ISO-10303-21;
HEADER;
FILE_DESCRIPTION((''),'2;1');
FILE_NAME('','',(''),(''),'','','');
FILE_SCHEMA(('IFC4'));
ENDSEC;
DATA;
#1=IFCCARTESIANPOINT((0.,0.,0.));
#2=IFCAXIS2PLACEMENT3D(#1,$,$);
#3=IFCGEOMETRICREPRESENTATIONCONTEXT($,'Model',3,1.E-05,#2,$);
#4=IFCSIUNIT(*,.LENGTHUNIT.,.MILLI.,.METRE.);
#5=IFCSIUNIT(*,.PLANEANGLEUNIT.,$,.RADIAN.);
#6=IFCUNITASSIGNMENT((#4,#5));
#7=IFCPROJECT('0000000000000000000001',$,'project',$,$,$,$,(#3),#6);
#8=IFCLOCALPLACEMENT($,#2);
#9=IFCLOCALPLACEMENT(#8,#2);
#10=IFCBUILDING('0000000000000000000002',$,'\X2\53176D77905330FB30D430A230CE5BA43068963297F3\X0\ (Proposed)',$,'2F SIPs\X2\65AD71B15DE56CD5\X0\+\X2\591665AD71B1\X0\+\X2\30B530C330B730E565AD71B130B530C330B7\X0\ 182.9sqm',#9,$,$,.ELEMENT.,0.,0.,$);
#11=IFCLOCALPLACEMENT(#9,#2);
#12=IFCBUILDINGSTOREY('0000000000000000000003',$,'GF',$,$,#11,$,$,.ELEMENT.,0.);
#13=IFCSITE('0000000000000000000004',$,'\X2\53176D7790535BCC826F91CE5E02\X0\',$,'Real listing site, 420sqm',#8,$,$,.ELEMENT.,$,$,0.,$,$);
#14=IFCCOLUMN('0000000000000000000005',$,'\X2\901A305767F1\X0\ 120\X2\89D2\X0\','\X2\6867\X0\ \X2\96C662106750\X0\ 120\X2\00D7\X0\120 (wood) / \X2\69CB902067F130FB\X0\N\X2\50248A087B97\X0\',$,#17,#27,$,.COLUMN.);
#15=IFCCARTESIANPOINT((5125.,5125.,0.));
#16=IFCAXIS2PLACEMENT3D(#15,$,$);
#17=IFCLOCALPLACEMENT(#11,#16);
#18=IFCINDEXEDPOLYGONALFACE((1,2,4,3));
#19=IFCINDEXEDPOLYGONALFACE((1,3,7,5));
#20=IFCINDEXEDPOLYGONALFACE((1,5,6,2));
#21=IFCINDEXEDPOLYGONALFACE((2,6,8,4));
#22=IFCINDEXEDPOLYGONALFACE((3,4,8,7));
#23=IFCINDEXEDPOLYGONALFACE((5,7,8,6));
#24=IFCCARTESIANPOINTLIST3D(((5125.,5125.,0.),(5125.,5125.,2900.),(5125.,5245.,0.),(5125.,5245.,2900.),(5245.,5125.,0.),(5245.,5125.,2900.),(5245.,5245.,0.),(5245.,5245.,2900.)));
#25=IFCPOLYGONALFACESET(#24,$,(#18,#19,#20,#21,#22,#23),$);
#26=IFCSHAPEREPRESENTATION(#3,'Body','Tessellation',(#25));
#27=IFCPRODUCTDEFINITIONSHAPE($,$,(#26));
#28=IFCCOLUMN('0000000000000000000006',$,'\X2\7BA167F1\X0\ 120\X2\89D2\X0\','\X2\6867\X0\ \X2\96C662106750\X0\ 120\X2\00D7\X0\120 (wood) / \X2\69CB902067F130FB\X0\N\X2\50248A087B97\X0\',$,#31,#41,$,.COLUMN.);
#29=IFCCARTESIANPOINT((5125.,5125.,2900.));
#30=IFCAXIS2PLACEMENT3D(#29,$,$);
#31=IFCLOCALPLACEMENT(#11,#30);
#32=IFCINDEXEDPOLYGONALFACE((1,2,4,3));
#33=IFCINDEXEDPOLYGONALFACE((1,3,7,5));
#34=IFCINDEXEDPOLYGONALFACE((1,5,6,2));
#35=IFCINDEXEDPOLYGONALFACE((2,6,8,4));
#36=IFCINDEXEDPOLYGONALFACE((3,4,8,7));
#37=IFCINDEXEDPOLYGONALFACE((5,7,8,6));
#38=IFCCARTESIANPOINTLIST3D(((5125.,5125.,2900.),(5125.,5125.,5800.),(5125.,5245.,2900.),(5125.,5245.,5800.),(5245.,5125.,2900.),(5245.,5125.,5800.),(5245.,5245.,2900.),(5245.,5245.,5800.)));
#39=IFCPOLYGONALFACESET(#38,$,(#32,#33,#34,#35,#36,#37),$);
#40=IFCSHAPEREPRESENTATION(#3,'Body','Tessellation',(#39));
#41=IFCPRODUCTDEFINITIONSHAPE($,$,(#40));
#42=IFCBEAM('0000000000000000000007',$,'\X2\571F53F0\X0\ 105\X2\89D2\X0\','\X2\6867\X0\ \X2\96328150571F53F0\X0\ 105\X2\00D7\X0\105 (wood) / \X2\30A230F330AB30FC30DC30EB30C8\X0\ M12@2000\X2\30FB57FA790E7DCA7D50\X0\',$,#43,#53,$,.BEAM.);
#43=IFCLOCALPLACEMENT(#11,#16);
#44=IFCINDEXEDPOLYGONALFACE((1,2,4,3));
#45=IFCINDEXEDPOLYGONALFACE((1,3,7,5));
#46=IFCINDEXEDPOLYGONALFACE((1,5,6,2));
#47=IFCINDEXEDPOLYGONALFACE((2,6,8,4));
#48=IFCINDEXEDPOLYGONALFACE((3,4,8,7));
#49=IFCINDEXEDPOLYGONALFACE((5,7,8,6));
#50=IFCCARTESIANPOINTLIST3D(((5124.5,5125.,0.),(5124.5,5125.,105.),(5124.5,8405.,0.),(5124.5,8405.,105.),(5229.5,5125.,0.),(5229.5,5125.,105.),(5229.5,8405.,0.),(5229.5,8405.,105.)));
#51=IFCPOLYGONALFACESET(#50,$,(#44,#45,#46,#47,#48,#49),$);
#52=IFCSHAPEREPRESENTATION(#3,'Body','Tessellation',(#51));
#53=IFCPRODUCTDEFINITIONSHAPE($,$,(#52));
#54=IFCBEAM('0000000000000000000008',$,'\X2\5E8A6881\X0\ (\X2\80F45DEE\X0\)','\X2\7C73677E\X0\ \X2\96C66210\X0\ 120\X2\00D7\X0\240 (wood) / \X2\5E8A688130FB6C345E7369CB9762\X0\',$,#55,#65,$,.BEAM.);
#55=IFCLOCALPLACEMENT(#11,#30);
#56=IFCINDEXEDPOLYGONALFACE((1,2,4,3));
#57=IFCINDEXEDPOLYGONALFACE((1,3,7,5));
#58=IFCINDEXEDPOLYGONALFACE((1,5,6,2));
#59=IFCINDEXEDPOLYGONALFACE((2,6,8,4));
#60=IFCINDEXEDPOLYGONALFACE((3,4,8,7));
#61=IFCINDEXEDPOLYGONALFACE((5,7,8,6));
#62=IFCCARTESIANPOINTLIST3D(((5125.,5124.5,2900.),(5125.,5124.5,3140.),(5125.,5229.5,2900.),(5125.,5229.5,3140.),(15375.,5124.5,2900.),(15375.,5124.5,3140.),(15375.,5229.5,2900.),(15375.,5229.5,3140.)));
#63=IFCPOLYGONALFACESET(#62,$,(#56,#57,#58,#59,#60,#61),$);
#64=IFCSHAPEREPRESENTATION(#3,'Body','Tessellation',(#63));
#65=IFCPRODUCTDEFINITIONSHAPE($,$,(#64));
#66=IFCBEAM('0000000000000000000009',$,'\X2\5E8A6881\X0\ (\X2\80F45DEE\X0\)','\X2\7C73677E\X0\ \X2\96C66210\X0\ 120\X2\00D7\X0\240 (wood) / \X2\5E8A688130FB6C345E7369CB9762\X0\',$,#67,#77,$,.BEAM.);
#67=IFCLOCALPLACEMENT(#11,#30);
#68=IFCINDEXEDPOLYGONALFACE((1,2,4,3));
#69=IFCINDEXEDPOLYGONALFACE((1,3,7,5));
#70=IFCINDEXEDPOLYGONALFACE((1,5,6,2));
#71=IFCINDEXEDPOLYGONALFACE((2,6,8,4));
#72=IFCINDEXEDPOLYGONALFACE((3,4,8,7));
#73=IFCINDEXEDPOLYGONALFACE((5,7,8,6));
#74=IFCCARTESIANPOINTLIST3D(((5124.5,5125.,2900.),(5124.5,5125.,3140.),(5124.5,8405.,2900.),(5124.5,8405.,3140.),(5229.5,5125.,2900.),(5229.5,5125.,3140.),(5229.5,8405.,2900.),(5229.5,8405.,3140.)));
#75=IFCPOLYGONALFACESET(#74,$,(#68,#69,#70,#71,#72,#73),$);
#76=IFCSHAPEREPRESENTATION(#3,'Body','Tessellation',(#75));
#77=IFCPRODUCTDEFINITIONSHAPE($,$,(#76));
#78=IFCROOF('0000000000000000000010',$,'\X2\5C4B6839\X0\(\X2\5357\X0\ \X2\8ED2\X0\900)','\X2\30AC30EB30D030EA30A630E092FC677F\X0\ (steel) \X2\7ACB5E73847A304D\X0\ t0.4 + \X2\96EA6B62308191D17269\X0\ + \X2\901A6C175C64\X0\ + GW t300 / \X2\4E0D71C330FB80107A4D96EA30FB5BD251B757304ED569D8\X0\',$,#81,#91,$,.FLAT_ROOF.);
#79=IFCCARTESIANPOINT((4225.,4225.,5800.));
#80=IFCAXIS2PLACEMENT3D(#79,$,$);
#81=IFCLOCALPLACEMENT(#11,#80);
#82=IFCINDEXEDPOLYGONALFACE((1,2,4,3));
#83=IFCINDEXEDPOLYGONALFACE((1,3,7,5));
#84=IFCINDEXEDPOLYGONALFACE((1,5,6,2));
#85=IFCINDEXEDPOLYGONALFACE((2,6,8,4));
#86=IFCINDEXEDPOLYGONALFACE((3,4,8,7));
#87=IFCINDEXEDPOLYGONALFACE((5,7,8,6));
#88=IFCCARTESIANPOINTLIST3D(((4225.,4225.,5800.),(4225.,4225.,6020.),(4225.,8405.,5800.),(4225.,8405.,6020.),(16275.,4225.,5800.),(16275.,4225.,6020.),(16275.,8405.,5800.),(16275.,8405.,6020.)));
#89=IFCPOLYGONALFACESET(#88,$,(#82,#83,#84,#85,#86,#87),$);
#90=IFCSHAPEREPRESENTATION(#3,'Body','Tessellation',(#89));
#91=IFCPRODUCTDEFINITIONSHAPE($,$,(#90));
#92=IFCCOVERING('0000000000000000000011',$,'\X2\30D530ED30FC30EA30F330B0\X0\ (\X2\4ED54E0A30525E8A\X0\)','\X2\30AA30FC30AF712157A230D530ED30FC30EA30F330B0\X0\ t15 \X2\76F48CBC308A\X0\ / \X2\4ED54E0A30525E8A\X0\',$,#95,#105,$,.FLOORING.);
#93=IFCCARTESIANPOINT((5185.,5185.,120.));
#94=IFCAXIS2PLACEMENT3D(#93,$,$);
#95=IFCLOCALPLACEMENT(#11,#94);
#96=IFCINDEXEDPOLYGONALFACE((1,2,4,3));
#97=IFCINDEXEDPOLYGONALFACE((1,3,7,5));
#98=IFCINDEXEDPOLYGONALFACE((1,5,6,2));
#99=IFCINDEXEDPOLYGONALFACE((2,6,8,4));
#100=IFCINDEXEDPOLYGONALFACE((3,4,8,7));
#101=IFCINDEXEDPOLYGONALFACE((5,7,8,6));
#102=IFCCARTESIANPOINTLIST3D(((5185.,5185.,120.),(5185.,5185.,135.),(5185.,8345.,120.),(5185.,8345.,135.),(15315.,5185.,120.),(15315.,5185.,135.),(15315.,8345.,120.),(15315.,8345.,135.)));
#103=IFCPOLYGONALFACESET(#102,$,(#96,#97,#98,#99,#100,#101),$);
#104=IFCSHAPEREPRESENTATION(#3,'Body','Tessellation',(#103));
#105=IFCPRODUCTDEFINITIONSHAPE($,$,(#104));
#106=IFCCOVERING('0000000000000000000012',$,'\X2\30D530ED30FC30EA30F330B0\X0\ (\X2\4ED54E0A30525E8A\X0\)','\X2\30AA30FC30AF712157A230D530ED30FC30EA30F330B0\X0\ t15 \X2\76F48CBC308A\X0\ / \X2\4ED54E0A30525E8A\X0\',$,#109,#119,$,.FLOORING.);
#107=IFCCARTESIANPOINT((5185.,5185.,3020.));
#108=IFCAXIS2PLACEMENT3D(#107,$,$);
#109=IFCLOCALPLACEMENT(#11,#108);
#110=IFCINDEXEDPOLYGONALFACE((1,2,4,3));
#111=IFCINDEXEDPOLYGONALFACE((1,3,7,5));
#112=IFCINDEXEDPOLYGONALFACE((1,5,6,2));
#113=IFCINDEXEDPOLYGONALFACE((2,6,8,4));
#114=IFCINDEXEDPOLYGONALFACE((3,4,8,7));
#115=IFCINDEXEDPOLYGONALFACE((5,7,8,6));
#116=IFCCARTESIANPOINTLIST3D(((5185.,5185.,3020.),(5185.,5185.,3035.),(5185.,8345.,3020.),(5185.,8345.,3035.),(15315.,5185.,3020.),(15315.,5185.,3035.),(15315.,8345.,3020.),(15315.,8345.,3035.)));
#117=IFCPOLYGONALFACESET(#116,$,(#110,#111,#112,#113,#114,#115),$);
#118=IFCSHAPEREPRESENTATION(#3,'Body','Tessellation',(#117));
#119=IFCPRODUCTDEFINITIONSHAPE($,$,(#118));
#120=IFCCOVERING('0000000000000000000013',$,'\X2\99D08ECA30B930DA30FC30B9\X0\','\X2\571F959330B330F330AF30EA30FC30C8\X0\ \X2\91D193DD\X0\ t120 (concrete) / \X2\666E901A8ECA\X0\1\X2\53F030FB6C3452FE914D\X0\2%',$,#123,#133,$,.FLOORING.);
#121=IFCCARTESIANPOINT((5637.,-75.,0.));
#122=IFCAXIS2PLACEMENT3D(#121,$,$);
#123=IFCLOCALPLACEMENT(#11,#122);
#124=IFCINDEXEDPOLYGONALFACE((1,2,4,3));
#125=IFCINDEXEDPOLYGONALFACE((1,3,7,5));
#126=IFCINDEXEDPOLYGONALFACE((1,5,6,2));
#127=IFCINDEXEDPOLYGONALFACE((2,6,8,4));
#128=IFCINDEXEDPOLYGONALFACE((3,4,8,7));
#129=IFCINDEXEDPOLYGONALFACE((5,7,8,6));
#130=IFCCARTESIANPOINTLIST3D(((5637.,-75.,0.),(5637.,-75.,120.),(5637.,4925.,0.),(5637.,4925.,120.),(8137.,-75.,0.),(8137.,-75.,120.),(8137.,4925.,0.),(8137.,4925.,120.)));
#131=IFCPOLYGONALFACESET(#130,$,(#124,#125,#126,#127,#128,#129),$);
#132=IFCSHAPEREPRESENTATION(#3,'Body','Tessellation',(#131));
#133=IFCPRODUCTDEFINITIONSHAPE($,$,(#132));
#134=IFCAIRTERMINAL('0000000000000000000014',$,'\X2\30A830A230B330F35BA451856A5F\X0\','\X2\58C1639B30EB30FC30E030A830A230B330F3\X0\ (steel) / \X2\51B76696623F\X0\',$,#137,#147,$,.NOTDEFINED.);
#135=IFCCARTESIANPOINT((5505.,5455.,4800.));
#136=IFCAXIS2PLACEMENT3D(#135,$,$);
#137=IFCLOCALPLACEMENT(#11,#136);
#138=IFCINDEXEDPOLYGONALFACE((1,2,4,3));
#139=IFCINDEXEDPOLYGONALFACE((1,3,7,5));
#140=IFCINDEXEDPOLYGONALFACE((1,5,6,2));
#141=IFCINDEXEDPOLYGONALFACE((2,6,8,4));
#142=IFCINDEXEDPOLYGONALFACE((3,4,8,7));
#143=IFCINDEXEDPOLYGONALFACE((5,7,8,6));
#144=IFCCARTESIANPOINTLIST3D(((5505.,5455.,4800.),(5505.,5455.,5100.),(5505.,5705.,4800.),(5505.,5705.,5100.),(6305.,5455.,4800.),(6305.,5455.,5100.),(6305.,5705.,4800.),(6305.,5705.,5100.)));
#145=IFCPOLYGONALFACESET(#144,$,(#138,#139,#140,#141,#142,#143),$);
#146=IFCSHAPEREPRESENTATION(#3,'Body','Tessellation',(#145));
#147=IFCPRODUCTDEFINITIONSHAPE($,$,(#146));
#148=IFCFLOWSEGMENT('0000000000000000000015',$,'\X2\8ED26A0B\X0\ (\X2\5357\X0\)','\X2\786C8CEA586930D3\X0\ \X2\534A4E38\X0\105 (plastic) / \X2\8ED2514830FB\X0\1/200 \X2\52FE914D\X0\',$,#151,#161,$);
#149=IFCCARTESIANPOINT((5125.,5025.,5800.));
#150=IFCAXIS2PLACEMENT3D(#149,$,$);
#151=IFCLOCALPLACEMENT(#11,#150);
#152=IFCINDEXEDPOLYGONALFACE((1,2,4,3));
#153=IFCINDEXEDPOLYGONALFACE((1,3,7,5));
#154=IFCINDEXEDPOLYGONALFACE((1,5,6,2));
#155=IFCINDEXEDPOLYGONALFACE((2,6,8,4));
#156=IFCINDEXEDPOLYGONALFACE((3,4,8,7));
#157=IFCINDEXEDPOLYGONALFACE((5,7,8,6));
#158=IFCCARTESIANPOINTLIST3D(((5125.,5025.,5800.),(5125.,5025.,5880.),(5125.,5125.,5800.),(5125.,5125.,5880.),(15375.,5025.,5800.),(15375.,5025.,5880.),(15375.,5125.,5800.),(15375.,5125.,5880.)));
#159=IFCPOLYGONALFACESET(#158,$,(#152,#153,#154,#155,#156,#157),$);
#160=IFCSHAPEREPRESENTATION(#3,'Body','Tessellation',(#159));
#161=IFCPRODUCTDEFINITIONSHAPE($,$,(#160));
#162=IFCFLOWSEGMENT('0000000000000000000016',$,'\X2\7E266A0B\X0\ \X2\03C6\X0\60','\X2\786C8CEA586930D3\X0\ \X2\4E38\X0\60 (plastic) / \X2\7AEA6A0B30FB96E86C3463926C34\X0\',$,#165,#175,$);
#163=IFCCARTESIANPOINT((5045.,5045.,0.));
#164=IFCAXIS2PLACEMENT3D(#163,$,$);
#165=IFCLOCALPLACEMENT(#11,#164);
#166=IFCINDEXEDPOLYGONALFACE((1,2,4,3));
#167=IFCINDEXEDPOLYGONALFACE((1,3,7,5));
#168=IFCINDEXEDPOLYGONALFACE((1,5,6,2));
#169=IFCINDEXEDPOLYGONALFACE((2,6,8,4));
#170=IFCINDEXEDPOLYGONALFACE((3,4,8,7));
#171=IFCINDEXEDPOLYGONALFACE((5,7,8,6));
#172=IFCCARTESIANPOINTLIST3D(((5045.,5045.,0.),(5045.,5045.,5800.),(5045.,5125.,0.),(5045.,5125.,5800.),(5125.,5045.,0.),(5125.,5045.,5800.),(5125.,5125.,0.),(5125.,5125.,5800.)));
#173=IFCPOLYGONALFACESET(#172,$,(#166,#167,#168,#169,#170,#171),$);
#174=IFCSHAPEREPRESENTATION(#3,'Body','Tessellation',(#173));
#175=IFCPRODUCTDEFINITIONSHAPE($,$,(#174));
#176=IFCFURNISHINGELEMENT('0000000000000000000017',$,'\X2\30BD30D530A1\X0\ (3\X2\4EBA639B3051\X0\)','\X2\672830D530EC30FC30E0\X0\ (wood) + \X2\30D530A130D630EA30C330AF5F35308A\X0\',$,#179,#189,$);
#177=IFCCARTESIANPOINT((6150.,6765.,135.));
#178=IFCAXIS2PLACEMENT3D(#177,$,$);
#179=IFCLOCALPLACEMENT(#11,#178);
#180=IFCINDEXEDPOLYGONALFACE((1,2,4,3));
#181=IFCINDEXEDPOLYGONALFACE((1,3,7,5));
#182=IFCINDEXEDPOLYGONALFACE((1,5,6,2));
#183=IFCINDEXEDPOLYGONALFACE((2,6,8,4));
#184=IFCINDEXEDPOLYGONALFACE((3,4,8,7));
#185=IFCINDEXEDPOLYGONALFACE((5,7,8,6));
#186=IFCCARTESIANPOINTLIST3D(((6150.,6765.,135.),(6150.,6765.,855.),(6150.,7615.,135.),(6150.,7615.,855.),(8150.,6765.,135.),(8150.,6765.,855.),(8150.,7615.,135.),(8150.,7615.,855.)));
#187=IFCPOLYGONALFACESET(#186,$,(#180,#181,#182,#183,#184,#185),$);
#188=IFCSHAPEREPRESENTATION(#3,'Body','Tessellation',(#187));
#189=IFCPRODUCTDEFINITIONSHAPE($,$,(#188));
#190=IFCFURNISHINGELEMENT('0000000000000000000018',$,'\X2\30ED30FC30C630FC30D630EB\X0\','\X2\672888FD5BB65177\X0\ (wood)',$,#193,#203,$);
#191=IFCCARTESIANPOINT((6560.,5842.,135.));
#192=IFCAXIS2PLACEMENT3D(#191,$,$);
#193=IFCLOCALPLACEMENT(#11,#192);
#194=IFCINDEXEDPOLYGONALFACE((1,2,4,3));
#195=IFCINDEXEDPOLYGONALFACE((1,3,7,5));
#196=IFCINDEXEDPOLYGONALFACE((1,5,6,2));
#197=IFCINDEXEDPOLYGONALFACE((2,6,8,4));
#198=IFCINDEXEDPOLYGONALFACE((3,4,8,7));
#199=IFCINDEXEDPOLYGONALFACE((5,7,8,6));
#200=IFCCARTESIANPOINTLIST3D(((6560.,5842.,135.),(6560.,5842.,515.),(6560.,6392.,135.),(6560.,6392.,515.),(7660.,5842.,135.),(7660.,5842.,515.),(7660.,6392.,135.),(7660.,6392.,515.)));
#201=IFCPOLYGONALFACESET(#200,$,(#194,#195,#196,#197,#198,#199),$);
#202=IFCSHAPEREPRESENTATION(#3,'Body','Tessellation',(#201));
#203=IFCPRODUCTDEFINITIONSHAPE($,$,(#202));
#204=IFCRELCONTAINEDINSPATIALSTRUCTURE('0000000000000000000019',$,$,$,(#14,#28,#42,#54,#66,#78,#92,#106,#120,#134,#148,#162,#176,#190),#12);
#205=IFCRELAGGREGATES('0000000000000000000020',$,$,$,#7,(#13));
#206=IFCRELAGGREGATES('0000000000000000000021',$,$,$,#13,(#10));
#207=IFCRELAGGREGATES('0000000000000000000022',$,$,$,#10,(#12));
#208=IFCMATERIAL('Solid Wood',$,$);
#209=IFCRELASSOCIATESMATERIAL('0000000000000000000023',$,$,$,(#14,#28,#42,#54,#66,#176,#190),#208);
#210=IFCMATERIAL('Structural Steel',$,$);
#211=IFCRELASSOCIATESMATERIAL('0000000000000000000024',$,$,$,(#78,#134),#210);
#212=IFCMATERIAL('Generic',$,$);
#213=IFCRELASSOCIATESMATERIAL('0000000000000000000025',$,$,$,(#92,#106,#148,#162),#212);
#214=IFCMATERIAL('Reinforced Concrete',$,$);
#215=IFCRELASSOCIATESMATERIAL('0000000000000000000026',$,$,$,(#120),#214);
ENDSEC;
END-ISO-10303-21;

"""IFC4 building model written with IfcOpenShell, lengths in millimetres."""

from ifc_helpers import new_model, si_unit, frame, frame_2d, origin, place, context, project, spatial, rectangle, extrude, material, element, save


model = new_model("IFC4")

# Units and contexts
model_context = context("Model", 3, precision=1e-05, world=origin())
ifc_project = project(units=[si_unit("LENGTHUNIT", "METRE", prefix="MILLI"), si_unit("PLANEANGLEUNIT", "RADIAN")], contexts=[model_context])

# Site, building, storey
site_placement = place(None, origin())
site = spatial("IfcSite", under=ifc_project, at=site_placement, Name="北海道富良野市", ObjectType="Real listing site, 420sqm", CompositionType="ELEMENT", RefElevation=0.0)
building_placement = place(site_placement, origin())
building = spatial("IfcBuilding", under=site, at=building_placement, Name="北海道・ピアノ室と防音 (Proposed)", ObjectType="2F SIPs断熱工法+外断熱+サッシュ断熱サッシ 182.9sqm", CompositionType="ELEMENT", ElevationOfRefHeight=0.0, ElevationOfTerrain=0.0)
storey_placement = place(building_placement, origin())
storey = spatial("IfcBuildingStorey", under=building, at=storey_placement, Name="GF", CompositionType="ELEMENT", Elevation=0.0)

# Columns
ifc_material_1 = material(Name="Solid Wood")
column_1_placement = place(storey_placement, frame((5125.0, 5125.0, 0.0)))
element("IfcColumn", 1, at=column_1_placement, inside=storey, material=ifc_material_1, Name="通し柱 120角", Description="桧 集成材 120×120 (wood) / 構造柱・N値計算", PredefinedType="COLUMN", context=model_context, shape_type="SweptSolid", body=[
    extrude(rectangle(XDim=120.0, YDim=120.0, at=frame_2d((60.0, 60.0))), frame((5125.0, 5125.0, 0.0)), (0.0, 0.0, 1.0), 2900.0),
])
column_2_placement = place(storey_placement, frame((5125.0, 5125.0, 2900.0)))
element("IfcColumn", 2, at=column_2_placement, inside=storey, material=ifc_material_1, Name="管柱 120角", Description="桧 集成材 120×120 (wood) / 構造柱・N値計算", PredefinedType="COLUMN", context=model_context, shape_type="SweptSolid", body=[
    extrude(rectangle(XDim=120.0, YDim=120.0, at=frame_2d((60.0, 60.0))), frame((5125.0, 5125.0, 2900.0)), (0.0, 0.0, 1.0), 2900.0),
])

# Beams
beam_1_placement = place(storey_placement, frame((5125.0, 5125.0, 0.0)))
element("IfcBeam", 3, at=beam_1_placement, inside=storey, material=ifc_material_1, Name="土台 105角", Description="桧 防腐土台 105×105 (wood) / アンカーボルト M12@2000・基礎緊結", PredefinedType="BEAM", context=model_context, shape_type="SweptSolid", body=[
    extrude(rectangle(XDim=105.0, YDim=3280.0, at=frame_2d((52.0, 1640.0))), frame((5125.0, 5125.0, 0.0)), (0.0, 0.0, 1.0), 105.0),
])
beam_2_placement = place(storey_placement, frame((5125.0, 5125.0, 2900.0)))
element("IfcBeam", 4, at=beam_2_placement, inside=storey, material=ifc_material_1, Name="床梁 (胴差)", Description="米松 集成 120×240 (wood) / 床梁・水平構面", PredefinedType="BEAM", context=model_context, shape_type="SweptSolid", body=[
    extrude(rectangle(XDim=10250.0, YDim=105.0, at=frame_2d((5125.0, 52.0))), frame((5125.0, 5125.0, 2900.0)), (0.0, 0.0, 1.0), 240.0),
])
beam_3_placement = place(storey_placement, frame((5125.0, 5125.0, 2900.0)))
element("IfcBeam", 5, at=beam_3_placement, inside=storey, material=ifc_material_1, Name="床梁 (胴差)", Description="米松 集成 120×240 (wood) / 床梁・水平構面", PredefinedType="BEAM", context=model_context, shape_type="SweptSolid", body=[
    extrude(rectangle(XDim=105.0, YDim=3280.0, at=frame_2d((52.0, 1640.0))), frame((5125.0, 5125.0, 2900.0)), (0.0, 0.0, 1.0), 240.0),
])

# Shared definitions
ifc_material_2 = material(Name="Reinforced Concrete")

# Roof
ifc_material_3 = material(Name="Structural Steel")
for number, where, name in (
    (6, (4225.0, 4225.0, 5800.0), "屋根(南 軒900)"),
):
    element("IfcRoof", number, at=place(storey_placement, frame(where)), inside=storey, material=ifc_material_3, Name=name, Description="ガルバリウム鋼板 (steel) 立平葺き t0.4 + 雪止め金物 + 通気層 + GW t300 / 不燃・耐積雪・寒冷地仕様", PredefinedType="FLAT_ROOF", context=model_context, shape_type="SweptSolid", body=[
        extrude(rectangle(XDim=12050.0, YDim=4180.0, at=frame_2d((6025.0, 2090.0))), frame((4225.0, 4225.0, 5800.0)), (0.0, 0.0, 1.0), 220.0),
    ])

# Coverings
ifc_material_4 = material(Name="Generic")
covering_1_placement = place(storey_placement, frame((5185.0, 5185.0, 120.0)))
element("IfcCovering", 7, at=covering_1_placement, inside=storey, material=ifc_material_4, Name="フローリング (仕上げ床)", Description="オーク無垢フローリング t15 直貼り / 仕上げ床", PredefinedType="FLOORING", context=model_context, shape_type="SweptSolid", body=[
    extrude(rectangle(XDim=10130.0, YDim=3160.0, at=frame_2d((5065.0, 1580.0))), frame((5185.0, 5185.0, 120.0)), (0.0, 0.0, 1.0), 15.0),
])
covering_2_placement = place(storey_placement, frame((5185.0, 5185.0, 3020.0)))
element("IfcCovering", 8, at=covering_2_placement, inside=storey, material=ifc_material_4, Name="フローリング (仕上げ床)", Description="オーク無垢フローリング t15 直貼り / 仕上げ床", PredefinedType="FLOORING", context=model_context, shape_type="SweptSolid", body=[
    extrude(rectangle(XDim=10130.0, YDim=3160.0, at=frame_2d((5065.0, 1580.0))), frame((5185.0, 5185.0, 3020.0)), (0.0, 0.0, 1.0), 15.0),
])
covering_3_placement = place(storey_placement, frame((5637.0, -75.0, 0.0)))
element("IfcCovering", 9, at=covering_3_placement, inside=storey, material=ifc_material_2, Name="駐車スペース", Description="土間コンクリート 金鏝 t120 (concrete) / 普通車1台・水勾配2%", PredefinedType="FLOORING", context=model_context, shape_type="SweptSolid", body=[
    extrude(rectangle(XDim=2500.0, YDim=5000.0, at=frame_2d((1250.0, 2500.0))), frame((5637.0, -75.0, 0.0)), (0.0, 0.0, 1.0), 120.0),
])

# Air terminal
air_terminal_placement = place(storey_placement, frame((5505.0, 5455.0, 4800.0)))
element("IfcAirTerminal", 10, at=air_terminal_placement, inside=storey, material=ifc_material_3, Name="エアコン室内機", Description="壁掛ルームエアコン (steel) / 冷暖房", PredefinedType="NOTDEFINED", context=model_context, shape_type="SweptSolid", body=[
    extrude(rectangle(XDim=800.0, YDim=250.0, at=frame_2d((400.0, 125.0))), frame((5505.0, 5455.0, 4800.0)), (0.0, 0.0, 1.0), 300.0),
])

# Flow segments
flow_segment_1_placement = place(storey_placement, frame((5125.0, 5025.0, 5800.0)))
element("IfcFlowSegment", 11, at=flow_segment_1_placement, inside=storey, material=ifc_material_4, Name="軒樋 (南)", Description="硬質塩ビ 半丸105 (plastic) / 軒先・1/200 勾配", context=model_context, shape_type="SweptSolid", body=[
    extrude(rectangle(XDim=10250.0, YDim=100.0, at=frame_2d((5125.0, 50.0))), frame((5125.0, 5025.0, 5800.0)), (0.0, 0.0, 1.0), 80.0),
])
flow_segment_2_placement = place(storey_placement, frame((5045.0, 5045.0, 0.0)))
element("IfcFlowSegment", 12, at=flow_segment_2_placement, inside=storey, material=ifc_material_4, Name="縦樋 φ60", Description="硬質塩ビ 丸60 (plastic) / 竪樋・雨水排水", context=model_context, shape_type="SweptSolid", body=[
    extrude(rectangle(XDim=80.0, YDim=80.0, at=frame_2d((40.0, 40.0))), frame((5045.0, 5045.0, 0.0)), (0.0, 0.0, 1.0), 5800.0),
])

# Furnishing elements
furnishing_1_placement = place(storey_placement, frame((6150.0, 6765.0, 135.0)))
element("IfcFurnishingElement", 13, at=furnishing_1_placement, inside=storey, material=ifc_material_1, Name="ソファ (3人掛け)", Description="木フレーム (wood) + ファブリック張り", context=model_context, shape_type="SweptSolid", body=[
    extrude(rectangle(XDim=2000.0, YDim=850.0, at=frame_2d((1000.0, 425.0))), frame((6150.0, 6765.0, 135.0)), (0.0, 0.0, 1.0), 720.0),
])
furnishing_2_placement = place(storey_placement, frame((6560.0, 5842.0, 135.0)))
element("IfcFurnishingElement", 14, at=furnishing_2_placement, inside=storey, material=ifc_material_1, Name="ローテーブル", Description="木製家具 (wood)", context=model_context, shape_type="SweptSolid", body=[
    extrude(rectangle(XDim=1100.0, YDim=550.0, at=frame_2d((550.0, 275.0))), frame((6560.0, 5842.0, 135.0)), (0.0, 0.0, 1.0), 380.0),
])

save(model, "model.ifc")
